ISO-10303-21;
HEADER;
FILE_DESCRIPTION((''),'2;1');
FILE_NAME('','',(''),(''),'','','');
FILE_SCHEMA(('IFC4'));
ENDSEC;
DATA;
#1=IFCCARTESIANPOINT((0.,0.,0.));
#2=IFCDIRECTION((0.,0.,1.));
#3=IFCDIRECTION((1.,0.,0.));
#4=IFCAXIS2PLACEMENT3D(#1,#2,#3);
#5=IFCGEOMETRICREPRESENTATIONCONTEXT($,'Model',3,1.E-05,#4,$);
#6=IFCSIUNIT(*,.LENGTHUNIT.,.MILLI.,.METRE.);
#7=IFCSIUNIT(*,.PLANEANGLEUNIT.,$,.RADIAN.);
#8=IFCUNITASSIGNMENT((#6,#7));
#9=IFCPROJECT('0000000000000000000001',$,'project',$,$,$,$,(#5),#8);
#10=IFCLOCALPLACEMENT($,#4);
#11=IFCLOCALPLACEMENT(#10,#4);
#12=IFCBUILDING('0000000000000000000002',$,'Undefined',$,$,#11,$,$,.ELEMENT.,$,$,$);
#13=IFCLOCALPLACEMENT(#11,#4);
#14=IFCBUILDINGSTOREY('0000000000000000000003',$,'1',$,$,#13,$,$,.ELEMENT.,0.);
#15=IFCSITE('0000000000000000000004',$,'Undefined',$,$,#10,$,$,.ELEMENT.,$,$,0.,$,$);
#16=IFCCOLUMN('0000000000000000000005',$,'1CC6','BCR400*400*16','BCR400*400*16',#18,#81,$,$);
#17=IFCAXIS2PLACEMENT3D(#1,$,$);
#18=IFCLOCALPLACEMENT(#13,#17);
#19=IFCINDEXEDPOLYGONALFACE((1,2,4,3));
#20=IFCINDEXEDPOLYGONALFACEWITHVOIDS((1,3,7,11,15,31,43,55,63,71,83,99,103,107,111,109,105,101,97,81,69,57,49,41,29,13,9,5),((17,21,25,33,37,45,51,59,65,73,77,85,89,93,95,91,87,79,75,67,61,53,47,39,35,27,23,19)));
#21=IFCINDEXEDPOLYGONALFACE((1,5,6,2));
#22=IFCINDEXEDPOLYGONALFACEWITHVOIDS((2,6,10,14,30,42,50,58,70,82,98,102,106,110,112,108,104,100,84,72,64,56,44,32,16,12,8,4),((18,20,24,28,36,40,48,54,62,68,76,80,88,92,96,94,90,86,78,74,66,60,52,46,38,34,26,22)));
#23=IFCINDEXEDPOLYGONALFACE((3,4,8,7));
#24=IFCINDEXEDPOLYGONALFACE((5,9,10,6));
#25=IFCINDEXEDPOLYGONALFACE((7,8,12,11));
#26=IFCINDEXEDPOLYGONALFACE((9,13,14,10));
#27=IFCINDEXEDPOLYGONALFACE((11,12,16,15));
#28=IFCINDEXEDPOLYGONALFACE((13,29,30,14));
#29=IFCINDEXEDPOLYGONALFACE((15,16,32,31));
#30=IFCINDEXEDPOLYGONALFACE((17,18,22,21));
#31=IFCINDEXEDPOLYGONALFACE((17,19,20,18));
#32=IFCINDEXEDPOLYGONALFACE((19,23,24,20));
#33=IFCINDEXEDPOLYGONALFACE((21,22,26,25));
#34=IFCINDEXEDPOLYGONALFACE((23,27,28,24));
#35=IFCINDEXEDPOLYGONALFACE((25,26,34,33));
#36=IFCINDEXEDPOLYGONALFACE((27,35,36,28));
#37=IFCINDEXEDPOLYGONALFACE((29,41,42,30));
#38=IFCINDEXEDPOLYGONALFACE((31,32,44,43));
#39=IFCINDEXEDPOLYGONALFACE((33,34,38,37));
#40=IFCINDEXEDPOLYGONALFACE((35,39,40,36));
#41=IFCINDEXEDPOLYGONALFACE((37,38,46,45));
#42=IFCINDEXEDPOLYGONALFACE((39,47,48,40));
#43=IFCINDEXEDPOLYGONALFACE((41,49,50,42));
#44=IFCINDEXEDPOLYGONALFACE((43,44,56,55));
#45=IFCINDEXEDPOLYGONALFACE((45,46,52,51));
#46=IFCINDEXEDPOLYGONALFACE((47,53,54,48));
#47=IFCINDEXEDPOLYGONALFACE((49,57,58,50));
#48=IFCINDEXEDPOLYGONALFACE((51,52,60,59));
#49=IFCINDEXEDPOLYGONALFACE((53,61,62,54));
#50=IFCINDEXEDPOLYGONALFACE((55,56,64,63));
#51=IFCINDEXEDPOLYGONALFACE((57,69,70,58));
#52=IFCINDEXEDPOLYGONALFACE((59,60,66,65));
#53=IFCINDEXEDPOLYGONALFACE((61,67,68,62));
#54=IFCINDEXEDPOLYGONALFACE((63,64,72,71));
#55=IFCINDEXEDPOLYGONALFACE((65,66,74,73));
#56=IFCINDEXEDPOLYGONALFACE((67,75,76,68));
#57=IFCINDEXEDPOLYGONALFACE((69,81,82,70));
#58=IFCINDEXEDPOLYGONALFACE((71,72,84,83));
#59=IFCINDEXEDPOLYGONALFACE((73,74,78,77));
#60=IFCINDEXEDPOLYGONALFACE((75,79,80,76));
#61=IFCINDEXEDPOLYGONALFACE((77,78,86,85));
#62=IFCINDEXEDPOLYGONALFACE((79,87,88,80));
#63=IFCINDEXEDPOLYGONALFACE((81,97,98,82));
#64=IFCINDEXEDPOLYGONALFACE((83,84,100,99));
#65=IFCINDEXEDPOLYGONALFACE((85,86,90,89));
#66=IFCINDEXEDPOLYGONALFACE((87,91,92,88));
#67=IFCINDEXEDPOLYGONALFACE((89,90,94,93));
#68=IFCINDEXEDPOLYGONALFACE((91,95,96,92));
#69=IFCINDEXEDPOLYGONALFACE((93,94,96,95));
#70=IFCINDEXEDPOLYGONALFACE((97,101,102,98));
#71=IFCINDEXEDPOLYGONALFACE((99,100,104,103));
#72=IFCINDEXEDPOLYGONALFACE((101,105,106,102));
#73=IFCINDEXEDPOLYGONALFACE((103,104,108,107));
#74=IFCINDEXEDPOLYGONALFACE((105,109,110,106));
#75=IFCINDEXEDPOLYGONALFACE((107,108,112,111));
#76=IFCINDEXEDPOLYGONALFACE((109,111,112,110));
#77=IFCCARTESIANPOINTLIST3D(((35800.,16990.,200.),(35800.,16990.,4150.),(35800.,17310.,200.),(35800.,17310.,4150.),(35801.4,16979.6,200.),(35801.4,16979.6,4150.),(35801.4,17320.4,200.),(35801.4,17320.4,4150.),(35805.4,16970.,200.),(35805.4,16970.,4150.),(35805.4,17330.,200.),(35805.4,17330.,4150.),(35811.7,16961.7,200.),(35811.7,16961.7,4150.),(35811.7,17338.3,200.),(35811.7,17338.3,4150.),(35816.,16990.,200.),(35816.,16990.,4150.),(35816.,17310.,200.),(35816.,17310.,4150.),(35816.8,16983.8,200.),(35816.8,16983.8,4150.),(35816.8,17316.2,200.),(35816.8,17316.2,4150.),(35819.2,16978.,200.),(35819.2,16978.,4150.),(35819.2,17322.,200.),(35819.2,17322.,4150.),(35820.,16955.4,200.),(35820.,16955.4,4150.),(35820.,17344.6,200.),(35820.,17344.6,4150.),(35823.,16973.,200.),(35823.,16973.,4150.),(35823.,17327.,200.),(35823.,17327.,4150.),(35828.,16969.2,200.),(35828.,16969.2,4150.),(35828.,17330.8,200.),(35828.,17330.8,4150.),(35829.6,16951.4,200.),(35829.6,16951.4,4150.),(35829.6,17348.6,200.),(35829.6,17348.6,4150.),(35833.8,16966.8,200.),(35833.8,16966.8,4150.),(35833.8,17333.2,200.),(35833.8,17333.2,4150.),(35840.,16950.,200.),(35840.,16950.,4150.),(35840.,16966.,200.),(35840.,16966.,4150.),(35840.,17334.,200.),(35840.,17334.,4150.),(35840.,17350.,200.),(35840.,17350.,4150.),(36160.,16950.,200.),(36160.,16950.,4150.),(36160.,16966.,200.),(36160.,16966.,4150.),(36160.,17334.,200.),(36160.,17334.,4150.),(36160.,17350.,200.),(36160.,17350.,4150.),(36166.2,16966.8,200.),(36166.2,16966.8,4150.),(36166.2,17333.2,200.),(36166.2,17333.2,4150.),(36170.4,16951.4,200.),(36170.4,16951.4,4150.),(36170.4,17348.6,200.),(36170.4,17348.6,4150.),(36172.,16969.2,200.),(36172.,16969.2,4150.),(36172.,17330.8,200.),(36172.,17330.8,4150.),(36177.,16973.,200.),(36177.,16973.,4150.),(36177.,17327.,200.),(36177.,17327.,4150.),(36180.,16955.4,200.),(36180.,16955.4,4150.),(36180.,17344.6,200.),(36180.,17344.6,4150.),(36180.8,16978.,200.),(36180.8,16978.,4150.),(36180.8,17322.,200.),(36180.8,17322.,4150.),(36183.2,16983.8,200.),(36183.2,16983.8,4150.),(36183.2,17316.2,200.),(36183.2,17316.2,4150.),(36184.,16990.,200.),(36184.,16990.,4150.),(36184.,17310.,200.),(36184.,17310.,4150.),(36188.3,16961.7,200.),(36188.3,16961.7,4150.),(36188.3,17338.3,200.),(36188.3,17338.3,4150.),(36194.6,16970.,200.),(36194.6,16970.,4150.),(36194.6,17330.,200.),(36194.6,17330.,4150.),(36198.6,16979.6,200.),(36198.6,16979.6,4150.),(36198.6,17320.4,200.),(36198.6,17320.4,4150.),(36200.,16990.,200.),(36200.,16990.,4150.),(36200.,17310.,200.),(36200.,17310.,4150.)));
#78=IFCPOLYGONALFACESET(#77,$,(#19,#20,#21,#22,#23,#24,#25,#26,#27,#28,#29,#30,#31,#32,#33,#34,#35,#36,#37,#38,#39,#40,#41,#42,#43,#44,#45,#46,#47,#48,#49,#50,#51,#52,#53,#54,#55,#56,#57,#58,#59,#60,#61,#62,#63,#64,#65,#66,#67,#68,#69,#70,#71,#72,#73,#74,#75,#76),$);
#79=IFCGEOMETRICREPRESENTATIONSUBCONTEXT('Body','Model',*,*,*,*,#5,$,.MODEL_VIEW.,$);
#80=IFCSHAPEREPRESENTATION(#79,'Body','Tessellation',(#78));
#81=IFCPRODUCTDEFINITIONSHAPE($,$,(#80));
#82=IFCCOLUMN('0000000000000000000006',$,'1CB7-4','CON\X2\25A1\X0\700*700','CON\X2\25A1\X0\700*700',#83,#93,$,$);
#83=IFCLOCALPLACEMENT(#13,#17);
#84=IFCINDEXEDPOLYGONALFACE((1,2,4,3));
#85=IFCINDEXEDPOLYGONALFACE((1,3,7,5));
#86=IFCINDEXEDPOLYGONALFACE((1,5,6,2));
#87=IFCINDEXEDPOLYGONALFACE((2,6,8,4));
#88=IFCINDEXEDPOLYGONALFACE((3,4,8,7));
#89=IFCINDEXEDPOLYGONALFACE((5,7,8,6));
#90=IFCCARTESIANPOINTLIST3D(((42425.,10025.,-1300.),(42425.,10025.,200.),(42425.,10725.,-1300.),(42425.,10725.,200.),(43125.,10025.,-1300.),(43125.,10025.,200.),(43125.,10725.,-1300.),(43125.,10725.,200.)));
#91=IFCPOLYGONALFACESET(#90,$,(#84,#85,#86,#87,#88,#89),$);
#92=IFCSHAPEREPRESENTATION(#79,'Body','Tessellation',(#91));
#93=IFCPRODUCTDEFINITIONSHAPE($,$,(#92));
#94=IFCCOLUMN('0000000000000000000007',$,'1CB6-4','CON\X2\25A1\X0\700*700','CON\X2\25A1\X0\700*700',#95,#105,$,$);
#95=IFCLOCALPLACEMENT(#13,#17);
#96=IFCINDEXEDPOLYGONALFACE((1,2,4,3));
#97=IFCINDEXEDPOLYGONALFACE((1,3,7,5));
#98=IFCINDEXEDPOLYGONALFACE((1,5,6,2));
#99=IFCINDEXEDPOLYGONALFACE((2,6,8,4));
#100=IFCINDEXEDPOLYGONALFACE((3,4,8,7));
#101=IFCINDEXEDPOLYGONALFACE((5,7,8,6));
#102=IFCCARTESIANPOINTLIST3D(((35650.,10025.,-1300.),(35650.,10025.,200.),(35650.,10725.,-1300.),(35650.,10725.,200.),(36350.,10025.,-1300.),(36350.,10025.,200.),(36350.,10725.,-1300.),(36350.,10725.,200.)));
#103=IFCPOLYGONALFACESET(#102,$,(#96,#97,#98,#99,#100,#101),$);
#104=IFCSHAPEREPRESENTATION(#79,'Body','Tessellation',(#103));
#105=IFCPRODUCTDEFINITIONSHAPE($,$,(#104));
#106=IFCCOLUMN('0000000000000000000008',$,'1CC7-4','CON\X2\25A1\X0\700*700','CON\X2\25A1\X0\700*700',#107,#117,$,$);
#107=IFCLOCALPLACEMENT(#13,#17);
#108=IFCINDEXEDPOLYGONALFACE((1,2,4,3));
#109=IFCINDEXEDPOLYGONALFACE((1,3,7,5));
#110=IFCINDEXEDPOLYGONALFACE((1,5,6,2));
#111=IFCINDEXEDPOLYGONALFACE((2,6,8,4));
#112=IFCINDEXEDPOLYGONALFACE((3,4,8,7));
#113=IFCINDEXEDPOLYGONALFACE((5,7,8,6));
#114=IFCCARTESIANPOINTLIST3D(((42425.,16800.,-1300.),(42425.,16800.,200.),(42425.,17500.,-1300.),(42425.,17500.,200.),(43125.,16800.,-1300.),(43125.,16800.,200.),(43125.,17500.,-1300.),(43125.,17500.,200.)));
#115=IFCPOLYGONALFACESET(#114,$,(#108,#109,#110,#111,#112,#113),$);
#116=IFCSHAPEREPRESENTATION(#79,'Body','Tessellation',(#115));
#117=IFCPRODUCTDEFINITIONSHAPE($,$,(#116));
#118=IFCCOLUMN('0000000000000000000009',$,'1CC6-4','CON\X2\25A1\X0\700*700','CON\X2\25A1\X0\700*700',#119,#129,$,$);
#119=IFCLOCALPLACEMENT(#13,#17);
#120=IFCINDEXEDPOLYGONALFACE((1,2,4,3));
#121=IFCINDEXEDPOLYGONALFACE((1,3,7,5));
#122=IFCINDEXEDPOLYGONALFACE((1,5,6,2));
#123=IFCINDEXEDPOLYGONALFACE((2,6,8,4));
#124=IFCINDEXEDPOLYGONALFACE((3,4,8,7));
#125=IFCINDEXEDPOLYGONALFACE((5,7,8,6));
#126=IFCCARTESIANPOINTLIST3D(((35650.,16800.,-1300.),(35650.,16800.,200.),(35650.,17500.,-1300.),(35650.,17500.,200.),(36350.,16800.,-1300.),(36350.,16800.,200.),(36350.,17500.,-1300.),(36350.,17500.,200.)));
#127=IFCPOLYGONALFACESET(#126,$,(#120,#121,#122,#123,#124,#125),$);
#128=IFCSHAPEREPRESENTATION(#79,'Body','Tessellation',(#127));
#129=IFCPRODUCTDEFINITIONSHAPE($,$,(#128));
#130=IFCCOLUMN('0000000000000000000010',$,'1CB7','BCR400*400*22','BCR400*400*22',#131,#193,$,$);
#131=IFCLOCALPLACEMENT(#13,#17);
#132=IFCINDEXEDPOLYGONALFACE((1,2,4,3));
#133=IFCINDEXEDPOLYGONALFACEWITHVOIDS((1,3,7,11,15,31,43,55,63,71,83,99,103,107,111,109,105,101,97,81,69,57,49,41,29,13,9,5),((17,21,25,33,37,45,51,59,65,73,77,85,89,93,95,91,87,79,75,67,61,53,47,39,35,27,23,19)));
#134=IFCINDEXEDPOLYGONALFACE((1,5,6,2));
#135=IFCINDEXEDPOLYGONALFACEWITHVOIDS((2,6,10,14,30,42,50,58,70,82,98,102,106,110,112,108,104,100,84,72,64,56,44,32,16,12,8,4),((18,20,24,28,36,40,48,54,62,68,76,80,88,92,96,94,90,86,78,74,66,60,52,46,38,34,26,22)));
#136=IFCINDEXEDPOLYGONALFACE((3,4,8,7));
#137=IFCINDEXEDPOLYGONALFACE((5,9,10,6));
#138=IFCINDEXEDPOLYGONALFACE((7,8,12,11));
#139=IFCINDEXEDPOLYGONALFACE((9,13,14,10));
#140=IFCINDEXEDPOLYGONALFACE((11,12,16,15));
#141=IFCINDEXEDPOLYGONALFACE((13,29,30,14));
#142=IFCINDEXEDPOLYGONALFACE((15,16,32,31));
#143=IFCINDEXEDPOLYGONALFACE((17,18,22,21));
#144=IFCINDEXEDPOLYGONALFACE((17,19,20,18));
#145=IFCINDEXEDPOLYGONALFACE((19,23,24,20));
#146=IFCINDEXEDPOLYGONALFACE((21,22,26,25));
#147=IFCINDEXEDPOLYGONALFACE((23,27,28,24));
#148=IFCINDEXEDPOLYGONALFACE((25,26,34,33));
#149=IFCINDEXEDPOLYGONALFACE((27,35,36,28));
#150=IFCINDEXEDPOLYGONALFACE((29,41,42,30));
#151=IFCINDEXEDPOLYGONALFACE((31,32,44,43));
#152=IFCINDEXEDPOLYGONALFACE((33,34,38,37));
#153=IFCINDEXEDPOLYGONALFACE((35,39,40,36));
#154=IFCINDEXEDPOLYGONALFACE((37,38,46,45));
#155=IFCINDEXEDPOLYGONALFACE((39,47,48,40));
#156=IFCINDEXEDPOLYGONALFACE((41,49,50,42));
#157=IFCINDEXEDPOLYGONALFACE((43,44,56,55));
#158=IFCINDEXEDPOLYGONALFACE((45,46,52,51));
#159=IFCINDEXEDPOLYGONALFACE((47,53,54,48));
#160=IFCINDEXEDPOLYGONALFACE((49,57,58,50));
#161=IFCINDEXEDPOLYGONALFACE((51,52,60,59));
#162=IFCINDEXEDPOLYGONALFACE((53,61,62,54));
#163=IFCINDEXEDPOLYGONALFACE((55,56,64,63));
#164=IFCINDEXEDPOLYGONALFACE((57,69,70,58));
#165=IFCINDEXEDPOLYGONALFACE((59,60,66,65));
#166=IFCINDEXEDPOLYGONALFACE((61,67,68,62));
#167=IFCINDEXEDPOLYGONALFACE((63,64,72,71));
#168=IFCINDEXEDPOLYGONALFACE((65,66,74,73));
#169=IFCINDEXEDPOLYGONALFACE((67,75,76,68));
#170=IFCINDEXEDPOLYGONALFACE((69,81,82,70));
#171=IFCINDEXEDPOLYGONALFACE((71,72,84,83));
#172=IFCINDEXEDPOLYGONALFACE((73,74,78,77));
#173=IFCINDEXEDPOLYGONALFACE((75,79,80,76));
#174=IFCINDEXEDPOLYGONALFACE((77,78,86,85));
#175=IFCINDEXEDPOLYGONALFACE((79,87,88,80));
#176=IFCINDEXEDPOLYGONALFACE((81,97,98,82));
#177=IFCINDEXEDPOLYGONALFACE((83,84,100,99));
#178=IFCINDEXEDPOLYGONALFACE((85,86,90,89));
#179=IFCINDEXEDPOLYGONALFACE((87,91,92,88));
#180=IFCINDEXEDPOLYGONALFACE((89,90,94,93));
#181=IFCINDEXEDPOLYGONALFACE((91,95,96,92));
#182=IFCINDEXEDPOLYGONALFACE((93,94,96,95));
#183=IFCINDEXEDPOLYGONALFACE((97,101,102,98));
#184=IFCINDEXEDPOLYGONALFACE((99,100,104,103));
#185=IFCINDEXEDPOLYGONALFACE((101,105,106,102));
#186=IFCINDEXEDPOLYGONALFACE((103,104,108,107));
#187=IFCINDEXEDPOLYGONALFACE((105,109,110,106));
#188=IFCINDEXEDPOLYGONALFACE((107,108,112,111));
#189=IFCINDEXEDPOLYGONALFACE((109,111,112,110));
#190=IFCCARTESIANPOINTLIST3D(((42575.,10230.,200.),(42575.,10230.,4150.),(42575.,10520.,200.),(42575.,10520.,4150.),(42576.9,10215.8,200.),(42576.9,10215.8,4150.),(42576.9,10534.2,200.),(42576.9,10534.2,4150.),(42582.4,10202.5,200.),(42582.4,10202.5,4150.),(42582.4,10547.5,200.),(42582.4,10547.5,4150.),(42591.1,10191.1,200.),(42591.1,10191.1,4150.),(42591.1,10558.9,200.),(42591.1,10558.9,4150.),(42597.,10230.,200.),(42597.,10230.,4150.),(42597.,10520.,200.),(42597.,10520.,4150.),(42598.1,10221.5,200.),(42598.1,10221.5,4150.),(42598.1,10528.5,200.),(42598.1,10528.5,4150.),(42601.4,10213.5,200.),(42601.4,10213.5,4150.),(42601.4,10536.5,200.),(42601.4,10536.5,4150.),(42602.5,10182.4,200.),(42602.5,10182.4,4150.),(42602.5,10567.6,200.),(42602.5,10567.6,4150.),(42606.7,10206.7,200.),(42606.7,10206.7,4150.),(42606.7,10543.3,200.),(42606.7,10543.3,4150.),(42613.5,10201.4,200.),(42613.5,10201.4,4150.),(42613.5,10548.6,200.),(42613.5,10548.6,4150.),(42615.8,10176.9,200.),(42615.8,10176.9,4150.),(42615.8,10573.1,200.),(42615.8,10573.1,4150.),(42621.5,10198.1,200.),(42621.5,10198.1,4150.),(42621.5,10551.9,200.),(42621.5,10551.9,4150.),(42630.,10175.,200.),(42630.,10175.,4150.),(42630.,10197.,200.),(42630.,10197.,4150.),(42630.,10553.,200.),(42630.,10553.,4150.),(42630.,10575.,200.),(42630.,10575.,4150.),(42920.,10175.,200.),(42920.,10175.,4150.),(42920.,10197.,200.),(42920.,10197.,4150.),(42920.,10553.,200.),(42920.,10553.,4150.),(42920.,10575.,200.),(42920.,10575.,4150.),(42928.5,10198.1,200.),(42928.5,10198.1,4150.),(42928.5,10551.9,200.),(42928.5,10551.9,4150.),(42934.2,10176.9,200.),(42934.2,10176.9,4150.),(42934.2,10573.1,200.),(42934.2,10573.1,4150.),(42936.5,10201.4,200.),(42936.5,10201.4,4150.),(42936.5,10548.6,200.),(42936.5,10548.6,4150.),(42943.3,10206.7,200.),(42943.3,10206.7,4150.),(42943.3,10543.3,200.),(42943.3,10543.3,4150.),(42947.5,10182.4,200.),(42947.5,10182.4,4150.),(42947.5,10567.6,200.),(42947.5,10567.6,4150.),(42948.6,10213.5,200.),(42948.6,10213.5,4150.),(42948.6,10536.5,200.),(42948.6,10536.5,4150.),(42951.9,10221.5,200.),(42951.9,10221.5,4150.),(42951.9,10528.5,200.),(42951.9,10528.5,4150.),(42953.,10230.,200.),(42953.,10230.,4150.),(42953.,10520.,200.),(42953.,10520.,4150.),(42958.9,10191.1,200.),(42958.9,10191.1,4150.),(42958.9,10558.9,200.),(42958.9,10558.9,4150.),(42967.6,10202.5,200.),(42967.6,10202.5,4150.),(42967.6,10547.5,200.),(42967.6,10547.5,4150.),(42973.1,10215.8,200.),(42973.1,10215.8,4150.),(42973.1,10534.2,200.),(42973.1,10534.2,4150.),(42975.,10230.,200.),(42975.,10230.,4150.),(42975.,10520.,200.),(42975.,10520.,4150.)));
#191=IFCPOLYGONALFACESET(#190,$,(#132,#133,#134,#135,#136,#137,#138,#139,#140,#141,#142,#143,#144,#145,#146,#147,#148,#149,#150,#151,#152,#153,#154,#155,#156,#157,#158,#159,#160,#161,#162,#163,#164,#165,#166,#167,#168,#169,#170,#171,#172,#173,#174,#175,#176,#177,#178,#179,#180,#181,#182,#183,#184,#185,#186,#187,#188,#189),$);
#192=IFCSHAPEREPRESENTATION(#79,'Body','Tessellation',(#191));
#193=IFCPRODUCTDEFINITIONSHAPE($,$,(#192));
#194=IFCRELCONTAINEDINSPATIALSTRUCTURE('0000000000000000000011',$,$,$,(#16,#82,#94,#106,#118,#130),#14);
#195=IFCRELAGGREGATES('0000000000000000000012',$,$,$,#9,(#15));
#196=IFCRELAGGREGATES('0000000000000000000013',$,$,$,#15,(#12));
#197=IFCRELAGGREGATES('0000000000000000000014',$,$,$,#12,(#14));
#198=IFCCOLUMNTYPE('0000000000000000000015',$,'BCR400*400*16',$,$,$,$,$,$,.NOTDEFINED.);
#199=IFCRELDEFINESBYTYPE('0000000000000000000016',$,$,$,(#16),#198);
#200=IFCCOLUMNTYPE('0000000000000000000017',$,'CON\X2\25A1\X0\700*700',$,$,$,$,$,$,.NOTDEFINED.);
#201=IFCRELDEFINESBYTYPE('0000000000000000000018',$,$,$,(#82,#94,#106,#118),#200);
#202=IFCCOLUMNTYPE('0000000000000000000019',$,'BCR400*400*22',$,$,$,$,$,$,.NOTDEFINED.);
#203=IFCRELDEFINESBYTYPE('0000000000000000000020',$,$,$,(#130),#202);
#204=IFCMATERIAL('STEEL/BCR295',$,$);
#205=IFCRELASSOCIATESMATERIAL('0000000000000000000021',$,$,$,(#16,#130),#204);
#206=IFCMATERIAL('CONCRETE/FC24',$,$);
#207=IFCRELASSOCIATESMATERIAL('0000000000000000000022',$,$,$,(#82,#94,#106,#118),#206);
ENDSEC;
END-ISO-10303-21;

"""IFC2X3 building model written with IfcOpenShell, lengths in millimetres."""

from ifc_helpers import new_model, si_unit, frame, origin_with_axes, origin_2d_with_axis, place, context, subcontext, project, spatial, rectangle, hollow_rectangle, extrude, material, type_object, element, save


model = new_model("IFC2X3")

# Units and contexts
model_context = context("Model", 3, precision=1e-05, world=origin_with_axes())
body_context = subcontext(model_context, "Body", "Model", "MODEL_VIEW")
ifc_project = project(units=[si_unit("LENGTHUNIT", "METRE", prefix="MILLI"), si_unit("PLANEANGLEUNIT", "RADIAN")], contexts=[model_context])

# Site, building, storey
site_placement = place(None, origin_with_axes())
site = spatial("IfcSite", under=ifc_project, at=site_placement, Name="Undefined", CompositionType="ELEMENT", RefElevation=0.0)
building_placement = place(site_placement, origin_with_axes())
building = spatial("IfcBuilding", under=site, at=building_placement, Name="Undefined", CompositionType="ELEMENT")
storey_placement = place(building_placement, origin_with_axes())
storey = spatial("IfcBuildingStorey", under=building, at=storey_placement, Name="1", CompositionType="ELEMENT", Elevation=0.0)

# Shared definitions
ifc_material_1 = material(Name="CONCRETE/FC24")

# Columns
ifc_material_2 = material(Name="STEEL/BCR295")
column_type_1 = type_object("IfcColumnType", Name="BCR400*400*16", PredefinedType="NOTDEFINED")
for number, where, z_axis, x_axis, name in (
    (1, (36000.0, 17150.0, 200.0), (0.0, 0.0, 1.0), (0.0, 1.0, 0.0), "1CC6"),
):
    element("IfcColumn", number, at=place(storey_placement, frame(where, z_axis=z_axis, x_axis=x_axis)), inside=storey, type_object=column_type_1, material=ifc_material_2, Name=name, Description="BCR400*400*16", ObjectType="BCR400*400*16", context=body_context, shape_type="SweptSolid", body=[
        extrude(hollow_rectangle(XDim=400.0, YDim=400.0, WallThickness=16.0, InnerFilletRadius=24.0, OuterFilletRadius=40.0, at=origin_2d_with_axis()), frame((0.0, 0.0, 3950.0), z_axis=(0.0, 0.0, -1.0), x_axis=(0.0, 1.0, 0.0)), (0.0, 0.0, 1.0), 3950.0),
    ])
column_type_2 = type_object("IfcColumnType", Name="CON□700*700", PredefinedType="NOTDEFINED")
for number, where, z_axis, x_axis, name in (
    (2, (42775.0, 10375.0, -1300.0), (0.0, 0.0, 1.0), (0.0, 1.0, 0.0), "1CB7-4"),
    (3, (36000.0, 10375.0, -1300.0), (0.0, 0.0, 1.0), (0.0, 1.0, 0.0), "1CB6-4"),
    (4, (42775.0, 17150.0, -1300.0), (0.0, 0.0, 1.0), (0.0, 1.0, 0.0), "1CC7-4"),
    (5, (36000.0, 17150.0, -1300.0), (0.0, 0.0, 1.0), (0.0, 1.0, 0.0), "1CC6-4"),
):
    element("IfcColumn", number, at=place(storey_placement, frame(where, z_axis=z_axis, x_axis=x_axis)), inside=storey, type_object=column_type_2, material=ifc_material_1, Name=name, Description="CON□700*700", ObjectType="CON□700*700", context=body_context, shape_type="SweptSolid", body=[
        extrude(rectangle(XDim=700.0, YDim=700.0, at=origin_2d_with_axis()), frame((0.0, 0.0, 1500.0), z_axis=(0.0, 0.0, -1.0), x_axis=(0.0, 1.0, 0.0)), (0.0, 0.0, 1.0), 1500.0),
    ])
column_type_3 = type_object("IfcColumnType", Name="BCR400*400*22", PredefinedType="NOTDEFINED")
for number, where, z_axis, x_axis, name in (
    (6, (42775.0, 10375.0, 200.0), (0.0, 0.0, 1.0), (0.0, 1.0, 0.0), "1CB7"),
):
    element("IfcColumn", number, at=place(storey_placement, frame(where, z_axis=z_axis, x_axis=x_axis)), inside=storey, type_object=column_type_3, material=ifc_material_2, Name=name, Description="BCR400*400*22", ObjectType="BCR400*400*22", context=body_context, shape_type="SweptSolid", body=[
        extrude(hollow_rectangle(XDim=400.0, YDim=400.0, WallThickness=22.0, InnerFilletRadius=33.0, OuterFilletRadius=55.0, at=origin_2d_with_axis()), frame((0.0, 0.0, 3950.0), z_axis=(0.0, 0.0, -1.0), x_axis=(0.0, 1.0, 0.0)), (0.0, 0.0, 1.0), 3950.0),
    ])

save(model, "model.ifc")
